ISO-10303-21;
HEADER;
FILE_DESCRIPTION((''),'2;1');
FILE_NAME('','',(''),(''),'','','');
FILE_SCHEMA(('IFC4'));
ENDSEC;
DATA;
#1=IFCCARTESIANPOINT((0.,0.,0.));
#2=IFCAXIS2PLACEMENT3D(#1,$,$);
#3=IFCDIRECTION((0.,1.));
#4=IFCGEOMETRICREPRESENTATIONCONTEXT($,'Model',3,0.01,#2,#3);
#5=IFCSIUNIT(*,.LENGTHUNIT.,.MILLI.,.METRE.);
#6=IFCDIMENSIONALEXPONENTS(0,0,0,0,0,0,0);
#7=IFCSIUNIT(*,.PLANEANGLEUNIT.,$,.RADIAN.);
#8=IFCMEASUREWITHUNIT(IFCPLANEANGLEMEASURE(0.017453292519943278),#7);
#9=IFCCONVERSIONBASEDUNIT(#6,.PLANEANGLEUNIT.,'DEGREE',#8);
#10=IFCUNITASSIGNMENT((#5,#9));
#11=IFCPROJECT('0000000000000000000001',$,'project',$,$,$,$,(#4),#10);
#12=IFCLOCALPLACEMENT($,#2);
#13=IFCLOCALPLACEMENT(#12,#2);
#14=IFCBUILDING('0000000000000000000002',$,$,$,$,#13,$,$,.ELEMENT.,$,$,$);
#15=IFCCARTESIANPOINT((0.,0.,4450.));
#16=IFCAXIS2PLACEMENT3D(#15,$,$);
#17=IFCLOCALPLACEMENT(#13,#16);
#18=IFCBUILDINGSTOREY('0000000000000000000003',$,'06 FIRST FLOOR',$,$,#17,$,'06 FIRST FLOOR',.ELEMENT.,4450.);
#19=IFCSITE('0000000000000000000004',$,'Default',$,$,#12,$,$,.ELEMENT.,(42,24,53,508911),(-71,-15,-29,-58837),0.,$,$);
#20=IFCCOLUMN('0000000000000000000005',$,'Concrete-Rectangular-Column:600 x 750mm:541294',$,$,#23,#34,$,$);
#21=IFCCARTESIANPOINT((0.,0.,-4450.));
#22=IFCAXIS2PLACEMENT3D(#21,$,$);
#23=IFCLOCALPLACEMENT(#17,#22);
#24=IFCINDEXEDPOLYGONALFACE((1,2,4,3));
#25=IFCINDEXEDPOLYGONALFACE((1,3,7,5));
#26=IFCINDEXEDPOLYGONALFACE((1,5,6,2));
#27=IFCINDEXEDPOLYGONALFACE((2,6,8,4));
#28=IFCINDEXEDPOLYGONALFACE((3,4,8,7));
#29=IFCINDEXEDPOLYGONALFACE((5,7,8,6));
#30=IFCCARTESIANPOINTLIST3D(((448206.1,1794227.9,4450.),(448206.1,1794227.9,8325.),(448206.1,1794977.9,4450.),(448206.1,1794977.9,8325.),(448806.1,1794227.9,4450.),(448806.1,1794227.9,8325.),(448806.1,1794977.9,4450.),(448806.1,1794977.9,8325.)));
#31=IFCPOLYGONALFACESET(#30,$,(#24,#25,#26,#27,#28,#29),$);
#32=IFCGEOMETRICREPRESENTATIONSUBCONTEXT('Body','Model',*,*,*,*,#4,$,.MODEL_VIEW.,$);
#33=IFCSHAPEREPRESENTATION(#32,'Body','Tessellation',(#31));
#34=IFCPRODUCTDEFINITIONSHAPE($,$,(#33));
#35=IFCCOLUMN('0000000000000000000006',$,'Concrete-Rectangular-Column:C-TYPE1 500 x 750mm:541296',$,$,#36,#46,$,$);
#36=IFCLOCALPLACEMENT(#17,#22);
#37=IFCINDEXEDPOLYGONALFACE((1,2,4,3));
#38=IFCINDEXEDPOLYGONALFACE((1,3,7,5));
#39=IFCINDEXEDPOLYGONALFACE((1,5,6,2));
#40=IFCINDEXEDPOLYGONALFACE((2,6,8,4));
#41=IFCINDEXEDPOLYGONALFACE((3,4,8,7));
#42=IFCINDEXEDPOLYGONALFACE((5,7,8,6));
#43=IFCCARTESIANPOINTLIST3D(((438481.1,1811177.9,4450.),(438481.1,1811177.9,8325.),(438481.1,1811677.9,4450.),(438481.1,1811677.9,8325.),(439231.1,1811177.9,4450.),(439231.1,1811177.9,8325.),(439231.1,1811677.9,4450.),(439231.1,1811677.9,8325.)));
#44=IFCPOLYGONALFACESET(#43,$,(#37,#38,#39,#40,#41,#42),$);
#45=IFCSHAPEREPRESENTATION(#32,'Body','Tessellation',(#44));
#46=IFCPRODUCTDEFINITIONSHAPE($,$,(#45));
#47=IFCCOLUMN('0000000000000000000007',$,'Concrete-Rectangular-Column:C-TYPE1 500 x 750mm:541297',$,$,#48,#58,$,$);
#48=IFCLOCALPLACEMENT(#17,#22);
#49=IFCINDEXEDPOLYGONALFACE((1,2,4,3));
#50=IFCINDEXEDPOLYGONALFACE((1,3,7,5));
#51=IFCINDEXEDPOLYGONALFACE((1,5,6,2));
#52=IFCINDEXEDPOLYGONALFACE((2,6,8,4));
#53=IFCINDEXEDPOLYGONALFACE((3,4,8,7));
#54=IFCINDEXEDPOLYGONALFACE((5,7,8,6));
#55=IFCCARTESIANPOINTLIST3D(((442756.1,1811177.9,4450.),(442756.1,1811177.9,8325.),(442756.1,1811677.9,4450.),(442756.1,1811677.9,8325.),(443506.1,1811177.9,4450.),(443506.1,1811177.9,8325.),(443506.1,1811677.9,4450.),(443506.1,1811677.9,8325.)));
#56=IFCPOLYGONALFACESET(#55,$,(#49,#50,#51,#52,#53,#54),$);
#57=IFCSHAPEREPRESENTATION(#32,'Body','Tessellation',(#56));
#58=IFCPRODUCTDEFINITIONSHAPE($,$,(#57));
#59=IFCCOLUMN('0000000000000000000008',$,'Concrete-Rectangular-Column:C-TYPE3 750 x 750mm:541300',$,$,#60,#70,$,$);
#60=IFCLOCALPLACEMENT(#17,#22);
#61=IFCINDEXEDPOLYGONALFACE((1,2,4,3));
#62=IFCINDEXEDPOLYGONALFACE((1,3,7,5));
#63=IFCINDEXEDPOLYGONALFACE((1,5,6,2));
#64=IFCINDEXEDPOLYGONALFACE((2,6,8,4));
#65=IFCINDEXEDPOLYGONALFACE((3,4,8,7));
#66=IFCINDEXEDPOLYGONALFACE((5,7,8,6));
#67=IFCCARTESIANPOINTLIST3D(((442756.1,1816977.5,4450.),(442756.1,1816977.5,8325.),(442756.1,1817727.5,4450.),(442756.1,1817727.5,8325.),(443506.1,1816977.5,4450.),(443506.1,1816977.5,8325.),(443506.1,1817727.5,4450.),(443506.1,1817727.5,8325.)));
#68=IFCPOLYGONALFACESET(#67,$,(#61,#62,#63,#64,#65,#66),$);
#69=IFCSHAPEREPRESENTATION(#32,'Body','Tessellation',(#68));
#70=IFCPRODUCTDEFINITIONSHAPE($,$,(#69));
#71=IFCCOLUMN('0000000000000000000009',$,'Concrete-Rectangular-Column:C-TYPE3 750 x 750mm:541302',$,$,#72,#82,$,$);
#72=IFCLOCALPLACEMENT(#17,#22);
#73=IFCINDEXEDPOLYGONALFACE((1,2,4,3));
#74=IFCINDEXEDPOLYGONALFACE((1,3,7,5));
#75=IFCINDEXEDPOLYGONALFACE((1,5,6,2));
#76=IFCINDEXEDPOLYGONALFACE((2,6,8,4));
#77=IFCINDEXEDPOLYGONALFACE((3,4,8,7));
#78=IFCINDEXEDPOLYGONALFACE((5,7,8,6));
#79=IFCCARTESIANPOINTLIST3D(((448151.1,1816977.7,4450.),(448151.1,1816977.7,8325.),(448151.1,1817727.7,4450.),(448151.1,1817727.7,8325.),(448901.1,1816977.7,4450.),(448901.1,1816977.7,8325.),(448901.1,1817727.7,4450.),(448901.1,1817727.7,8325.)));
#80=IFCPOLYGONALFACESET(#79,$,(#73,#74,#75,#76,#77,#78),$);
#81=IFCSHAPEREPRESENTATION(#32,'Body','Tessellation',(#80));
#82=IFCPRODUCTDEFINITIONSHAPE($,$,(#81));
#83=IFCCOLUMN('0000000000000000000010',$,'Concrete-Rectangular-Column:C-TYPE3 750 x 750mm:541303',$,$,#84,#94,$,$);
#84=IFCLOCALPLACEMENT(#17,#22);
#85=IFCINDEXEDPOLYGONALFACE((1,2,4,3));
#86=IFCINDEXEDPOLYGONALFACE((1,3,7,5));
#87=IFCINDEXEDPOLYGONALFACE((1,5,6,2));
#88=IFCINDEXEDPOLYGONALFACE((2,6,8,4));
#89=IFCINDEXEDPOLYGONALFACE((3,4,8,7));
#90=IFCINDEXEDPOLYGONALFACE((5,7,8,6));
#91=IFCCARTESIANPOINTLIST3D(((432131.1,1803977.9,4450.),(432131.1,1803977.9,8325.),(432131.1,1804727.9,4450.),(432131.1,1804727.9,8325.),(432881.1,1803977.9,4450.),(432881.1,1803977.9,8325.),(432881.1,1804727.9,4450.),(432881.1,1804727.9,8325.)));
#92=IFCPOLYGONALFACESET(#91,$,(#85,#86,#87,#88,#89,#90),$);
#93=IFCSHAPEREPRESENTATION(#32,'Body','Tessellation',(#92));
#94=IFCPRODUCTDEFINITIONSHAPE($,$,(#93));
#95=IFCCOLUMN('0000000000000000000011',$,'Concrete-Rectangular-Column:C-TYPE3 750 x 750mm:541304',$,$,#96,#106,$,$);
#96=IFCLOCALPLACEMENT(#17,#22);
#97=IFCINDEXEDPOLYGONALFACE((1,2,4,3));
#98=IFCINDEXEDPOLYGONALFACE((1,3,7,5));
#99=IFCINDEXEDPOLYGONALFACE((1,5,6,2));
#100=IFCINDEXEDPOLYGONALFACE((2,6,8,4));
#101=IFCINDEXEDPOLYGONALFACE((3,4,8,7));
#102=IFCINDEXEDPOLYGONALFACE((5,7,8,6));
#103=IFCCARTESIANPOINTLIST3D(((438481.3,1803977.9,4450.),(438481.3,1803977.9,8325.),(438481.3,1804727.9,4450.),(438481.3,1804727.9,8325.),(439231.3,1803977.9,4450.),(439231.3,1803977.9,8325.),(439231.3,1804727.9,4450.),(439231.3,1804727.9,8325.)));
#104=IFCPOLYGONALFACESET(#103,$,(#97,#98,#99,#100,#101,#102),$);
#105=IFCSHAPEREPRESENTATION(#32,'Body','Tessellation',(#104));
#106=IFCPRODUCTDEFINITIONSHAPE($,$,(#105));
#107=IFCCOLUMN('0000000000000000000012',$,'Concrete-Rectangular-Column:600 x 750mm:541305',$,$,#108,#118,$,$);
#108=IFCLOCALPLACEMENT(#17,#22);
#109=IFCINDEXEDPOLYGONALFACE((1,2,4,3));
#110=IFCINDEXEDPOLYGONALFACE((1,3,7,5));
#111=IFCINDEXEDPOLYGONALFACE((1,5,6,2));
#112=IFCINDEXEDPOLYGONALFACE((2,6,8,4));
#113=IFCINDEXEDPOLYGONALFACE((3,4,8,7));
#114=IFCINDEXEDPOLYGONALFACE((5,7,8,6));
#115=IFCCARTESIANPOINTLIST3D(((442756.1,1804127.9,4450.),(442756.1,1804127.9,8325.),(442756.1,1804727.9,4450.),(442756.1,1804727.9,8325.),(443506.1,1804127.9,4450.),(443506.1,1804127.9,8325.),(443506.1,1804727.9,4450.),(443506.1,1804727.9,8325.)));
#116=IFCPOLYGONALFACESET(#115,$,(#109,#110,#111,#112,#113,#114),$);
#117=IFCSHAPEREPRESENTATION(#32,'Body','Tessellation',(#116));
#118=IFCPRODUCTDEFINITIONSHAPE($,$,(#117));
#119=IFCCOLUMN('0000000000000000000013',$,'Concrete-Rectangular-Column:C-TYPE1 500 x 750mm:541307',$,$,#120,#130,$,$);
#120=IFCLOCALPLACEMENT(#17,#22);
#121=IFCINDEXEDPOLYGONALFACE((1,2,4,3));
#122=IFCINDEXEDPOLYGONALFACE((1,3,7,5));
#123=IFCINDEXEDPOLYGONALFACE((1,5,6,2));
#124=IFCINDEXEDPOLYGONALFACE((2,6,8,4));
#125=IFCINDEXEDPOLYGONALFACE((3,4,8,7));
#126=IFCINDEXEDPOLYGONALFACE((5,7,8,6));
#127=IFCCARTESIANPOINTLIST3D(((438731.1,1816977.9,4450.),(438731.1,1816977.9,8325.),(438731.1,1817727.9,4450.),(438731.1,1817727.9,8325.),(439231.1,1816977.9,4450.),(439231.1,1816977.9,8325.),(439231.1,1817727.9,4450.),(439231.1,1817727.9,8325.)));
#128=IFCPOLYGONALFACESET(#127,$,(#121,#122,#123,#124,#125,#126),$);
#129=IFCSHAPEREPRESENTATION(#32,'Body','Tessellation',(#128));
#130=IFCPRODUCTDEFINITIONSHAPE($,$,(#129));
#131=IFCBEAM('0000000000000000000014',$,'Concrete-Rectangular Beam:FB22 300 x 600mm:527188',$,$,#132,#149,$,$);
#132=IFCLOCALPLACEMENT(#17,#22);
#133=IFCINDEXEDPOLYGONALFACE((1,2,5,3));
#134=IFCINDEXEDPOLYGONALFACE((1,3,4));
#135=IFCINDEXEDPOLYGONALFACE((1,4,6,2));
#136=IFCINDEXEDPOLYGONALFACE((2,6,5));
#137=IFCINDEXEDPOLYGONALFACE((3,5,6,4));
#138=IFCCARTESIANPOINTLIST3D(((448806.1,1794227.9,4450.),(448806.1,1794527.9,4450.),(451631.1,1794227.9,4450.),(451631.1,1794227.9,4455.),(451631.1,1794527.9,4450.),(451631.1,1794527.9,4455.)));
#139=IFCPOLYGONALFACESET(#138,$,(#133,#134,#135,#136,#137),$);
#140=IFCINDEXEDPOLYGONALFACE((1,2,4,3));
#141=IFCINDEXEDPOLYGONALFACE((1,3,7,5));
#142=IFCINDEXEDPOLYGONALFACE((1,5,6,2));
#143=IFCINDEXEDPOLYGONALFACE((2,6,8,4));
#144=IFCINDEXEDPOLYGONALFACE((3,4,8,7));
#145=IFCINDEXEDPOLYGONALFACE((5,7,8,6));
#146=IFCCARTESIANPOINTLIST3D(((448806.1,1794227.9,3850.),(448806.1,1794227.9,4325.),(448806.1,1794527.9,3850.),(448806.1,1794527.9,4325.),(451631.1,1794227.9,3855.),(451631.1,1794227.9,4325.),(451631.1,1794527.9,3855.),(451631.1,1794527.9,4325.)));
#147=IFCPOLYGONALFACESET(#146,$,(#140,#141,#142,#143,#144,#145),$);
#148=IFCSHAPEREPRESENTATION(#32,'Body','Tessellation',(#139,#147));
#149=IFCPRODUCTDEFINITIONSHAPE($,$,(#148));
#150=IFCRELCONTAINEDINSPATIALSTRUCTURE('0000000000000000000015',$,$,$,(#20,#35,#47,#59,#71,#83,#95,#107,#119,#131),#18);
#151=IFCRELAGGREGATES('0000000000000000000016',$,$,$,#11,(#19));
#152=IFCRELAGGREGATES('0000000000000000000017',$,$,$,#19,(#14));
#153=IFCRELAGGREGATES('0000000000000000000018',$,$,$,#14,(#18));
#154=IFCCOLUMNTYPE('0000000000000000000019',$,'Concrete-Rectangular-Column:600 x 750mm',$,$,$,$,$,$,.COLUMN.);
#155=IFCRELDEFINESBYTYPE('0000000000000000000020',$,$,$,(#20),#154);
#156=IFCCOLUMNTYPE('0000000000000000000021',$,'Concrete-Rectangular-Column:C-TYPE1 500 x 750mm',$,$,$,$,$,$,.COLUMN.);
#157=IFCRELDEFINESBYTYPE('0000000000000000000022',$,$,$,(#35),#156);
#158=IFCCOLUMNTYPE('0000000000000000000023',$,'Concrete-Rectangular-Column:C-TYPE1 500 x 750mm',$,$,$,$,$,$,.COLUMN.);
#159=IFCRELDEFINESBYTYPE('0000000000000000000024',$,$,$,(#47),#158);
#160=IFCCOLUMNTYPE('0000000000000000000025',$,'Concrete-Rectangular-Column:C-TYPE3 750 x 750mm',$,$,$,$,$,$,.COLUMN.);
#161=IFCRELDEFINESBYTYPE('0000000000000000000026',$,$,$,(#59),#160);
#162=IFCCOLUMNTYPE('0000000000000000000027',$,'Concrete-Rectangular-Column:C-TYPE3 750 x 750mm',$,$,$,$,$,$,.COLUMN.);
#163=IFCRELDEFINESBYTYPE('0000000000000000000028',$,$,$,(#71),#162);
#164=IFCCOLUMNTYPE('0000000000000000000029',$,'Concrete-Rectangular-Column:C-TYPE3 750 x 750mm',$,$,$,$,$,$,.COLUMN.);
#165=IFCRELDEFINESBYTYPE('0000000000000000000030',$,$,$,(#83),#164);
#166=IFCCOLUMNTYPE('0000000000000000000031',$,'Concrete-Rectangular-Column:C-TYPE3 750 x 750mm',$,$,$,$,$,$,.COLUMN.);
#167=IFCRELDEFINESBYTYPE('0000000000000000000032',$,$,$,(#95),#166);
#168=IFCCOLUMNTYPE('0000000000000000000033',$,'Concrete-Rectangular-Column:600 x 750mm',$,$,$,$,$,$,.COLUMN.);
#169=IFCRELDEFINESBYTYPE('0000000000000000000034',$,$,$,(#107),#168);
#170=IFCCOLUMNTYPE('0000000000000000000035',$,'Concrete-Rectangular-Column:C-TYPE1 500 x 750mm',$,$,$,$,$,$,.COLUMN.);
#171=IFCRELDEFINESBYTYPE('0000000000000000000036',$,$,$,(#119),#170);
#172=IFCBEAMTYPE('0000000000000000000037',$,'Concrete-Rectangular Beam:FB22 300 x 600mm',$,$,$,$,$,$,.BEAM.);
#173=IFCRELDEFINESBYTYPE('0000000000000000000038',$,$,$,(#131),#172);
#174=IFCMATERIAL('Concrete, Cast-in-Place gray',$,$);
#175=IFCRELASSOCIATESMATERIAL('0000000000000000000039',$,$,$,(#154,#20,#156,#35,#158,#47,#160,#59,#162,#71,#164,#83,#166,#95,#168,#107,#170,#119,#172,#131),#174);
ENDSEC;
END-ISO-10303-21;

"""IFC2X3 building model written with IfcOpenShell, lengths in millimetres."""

from ifc_helpers import new_model, entity, si_unit, converted_unit, direction, frame, frame_2d, origin, place, context, subcontext, project, spatial, polyline, rectangle, extrude, clip, halfspace, bounded_halfspace, source, transform, mapped, material, type_object, type_shapes, element, save


model = new_model("IFC2X3")

# Units and contexts
model_context = context("Model", 3, precision=0.01, world=origin(), true_north=direction((0.0, 1.0)))
body_context = subcontext(model_context, "Body", "Model", "MODEL_VIEW")
ifc_project = project(units=[si_unit("LENGTHUNIT", "METRE", prefix="MILLI"), converted_unit("PLANEANGLEUNIT", "DEGREE", entity("IfcPlaneAngleMeasure", 0.017453292519943278), si_unit("PLANEANGLEUNIT", "RADIAN"), dimensions=[0, 0, 0, 0, 0, 0, 0])], contexts=[model_context])

# Site, building, storey
site_placement = place(None, origin())
site = spatial("IfcSite", under=ifc_project, at=site_placement, Name="Default", CompositionType="ELEMENT", RefLatitude=(42, 24, 53, 508911), RefLongitude=(-71, -15, -29, -58837), RefElevation=0.0)
building_placement = place(site_placement, origin())
building = spatial("IfcBuilding", under=site, at=building_placement, CompositionType="ELEMENT")
storey_placement = place(building_placement, frame((0.0, 0.0, 4450.0)))
storey = spatial("IfcBuildingStorey", under=building, at=storey_placement, Name="06 FIRST FLOOR", LongName="06 FIRST FLOOR", CompositionType="ELEMENT", Elevation=4450.0)

# Columns
ifc_material_1 = material(Name="Concrete, Cast-in-Place gray")
column_type_1 = type_object("IfcColumnType", Name="Concrete-Rectangular-Column:600 x 750mm", PredefinedType="COLUMN", material=ifc_material_1)
shared_shape_1 = source(origin(), body_context, "Body", "SweptSolid", [
    extrude(rectangle(XDim=3875.0, YDim=750.0, at=frame_2d((0.0, 0.0), x_axis=(1.0, 0.0))), frame((448206.1, 1794602.9, 6387.5), z_axis=(1.0, 0.0, 0.0), x_axis=(0.0, 0.0, 1.0)), (0.0, 0.0, 1.0), 600.0),
])
type_shapes(column_type_1, [shared_shape_1])
column_1_placement = place(storey_placement, frame((0.0, 0.0, -4450.0)))
element("IfcColumn", 1, at=column_1_placement, inside=storey, type_object=column_type_1, material=ifc_material_1, Name="Concrete-Rectangular-Column:600 x 750mm:541294", context=body_context, shape_type="MappedRepresentation", body=[
    mapped(shared_shape_1, transform((0.0, 0.0, 0.0), scale=1.0)),
])
column_type_2 = type_object("IfcColumnType", Name="Concrete-Rectangular-Column:C-TYPE1 500 x 750mm", PredefinedType="COLUMN", material=ifc_material_1)
shared_shape_2 = source(origin(), body_context, "Body", "SweptSolid", [
    extrude(rectangle(XDim=500.0, YDim=750.0, at=frame_2d((0.0, 0.0), x_axis=(1.0, 0.0))), frame((438856.1, 1811427.9, 4450.0), z_axis=(0.0, 0.0, 1.0), x_axis=(0.0, -1.0, 0.0)), (0.0, 0.0, 1.0), 3875.0),
])
type_shapes(column_type_2, [shared_shape_2])
column_2_placement = place(storey_placement, frame((0.0, 0.0, -4450.0)))
element("IfcColumn", 2, at=column_2_placement, inside=storey, type_object=column_type_2, material=ifc_material_1, Name="Concrete-Rectangular-Column:C-TYPE1 500 x 750mm:541296", context=body_context, shape_type="MappedRepresentation", body=[
    mapped(shared_shape_2, transform((0.0, 0.0, 0.0), scale=1.0)),
])
column_type_3 = type_object("IfcColumnType", Name="Concrete-Rectangular-Column:C-TYPE1 500 x 750mm", PredefinedType="COLUMN", material=ifc_material_1)
shared_shape_3 = source(origin(), body_context, "Body", "SweptSolid", [
    extrude(rectangle(XDim=500.0, YDim=750.0, at=frame_2d((0.0, 0.0), x_axis=(1.0, 0.0))), frame((443131.1, 1811427.9, 4450.0), z_axis=(0.0, 0.0, 1.0), x_axis=(0.0, -1.0, 0.0)), (0.0, 0.0, 1.0), 3875.0),
])
type_shapes(column_type_3, [shared_shape_3])
column_3_placement = place(storey_placement, frame((0.0, 0.0, -4450.0)))
element("IfcColumn", 3, at=column_3_placement, inside=storey, type_object=column_type_3, material=ifc_material_1, Name="Concrete-Rectangular-Column:C-TYPE1 500 x 750mm:541297", context=body_context, shape_type="MappedRepresentation", body=[
    mapped(shared_shape_3, transform((0.0, 0.0, 0.0), scale=1.0)),
])
column_type_4 = type_object("IfcColumnType", Name="Concrete-Rectangular-Column:C-TYPE3 750 x 750mm", PredefinedType="COLUMN", material=ifc_material_1)
shared_shape_4 = source(origin(), body_context, "Body", "SweptSolid", [
    extrude(rectangle(XDim=750.0, YDim=750.0, at=frame_2d((0.0, 0.0), x_axis=(1.0, 0.0))), frame((443131.1, 1817352.5, 4450.0), z_axis=(0.0, 0.0, 1.0), x_axis=(0.0, -1.0, 0.0)), (0.0, 0.0, 1.0), 3875.0),
])
type_shapes(column_type_4, [shared_shape_4])
column_4_placement = place(storey_placement, frame((0.0, 0.0, -4450.0)))
element("IfcColumn", 4, at=column_4_placement, inside=storey, type_object=column_type_4, material=ifc_material_1, Name="Concrete-Rectangular-Column:C-TYPE3 750 x 750mm:541300", context=body_context, shape_type="MappedRepresentation", body=[
    mapped(shared_shape_4, transform((0.0, 0.0, 0.0), scale=1.0)),
])
column_type_5 = type_object("IfcColumnType", Name="Concrete-Rectangular-Column:C-TYPE3 750 x 750mm", PredefinedType="COLUMN", material=ifc_material_1)
shared_shape_5 = source(origin(), body_context, "Body", "SweptSolid", [
    extrude(rectangle(XDim=750.0, YDim=750.0, at=frame_2d((0.0, 0.0), x_axis=(1.0, 0.0))), frame((448526.1, 1817352.7, 4450.0), z_axis=(0.0, 0.0, 1.0), x_axis=(0.0, -1.0, 0.0)), (0.0, 0.0, 1.0), 3875.0),
])
type_shapes(column_type_5, [shared_shape_5])
column_5_placement = place(storey_placement, frame((0.0, 0.0, -4450.0)))
element("IfcColumn", 5, at=column_5_placement, inside=storey, type_object=column_type_5, material=ifc_material_1, Name="Concrete-Rectangular-Column:C-TYPE3 750 x 750mm:541302", context=body_context, shape_type="MappedRepresentation", body=[
    mapped(shared_shape_5, transform((0.0, 0.0, 0.0), scale=1.0)),
])
column_type_6 = type_object("IfcColumnType", Name="Concrete-Rectangular-Column:C-TYPE3 750 x 750mm", PredefinedType="COLUMN", material=ifc_material_1)
shared_shape_6 = source(origin(), body_context, "Body", "SweptSolid", [
    extrude(rectangle(XDim=750.0, YDim=750.0, at=frame_2d((0.0, 0.0), x_axis=(1.0, 0.0))), frame((432506.1, 1804352.9, 4450.0), z_axis=(0.0, 0.0, 1.0), x_axis=(0.0, -1.0, 0.0)), (0.0, 0.0, 1.0), 3875.0),
])
type_shapes(column_type_6, [shared_shape_6])
column_6_placement = place(storey_placement, frame((0.0, 0.0, -4450.0)))
element("IfcColumn", 6, at=column_6_placement, inside=storey, type_object=column_type_6, material=ifc_material_1, Name="Concrete-Rectangular-Column:C-TYPE3 750 x 750mm:541303", context=body_context, shape_type="MappedRepresentation", body=[
    mapped(shared_shape_6, transform((0.0, 0.0, 0.0), scale=1.0)),
])
column_type_7 = type_object("IfcColumnType", Name="Concrete-Rectangular-Column:C-TYPE3 750 x 750mm", PredefinedType="COLUMN", material=ifc_material_1)
shared_shape_7 = source(origin(), body_context, "Body", "SweptSolid", [
    extrude(rectangle(XDim=750.0, YDim=750.0, at=frame_2d((0.0, 0.0), x_axis=(1.0, 0.0))), frame((438856.3, 1804352.9, 4450.0), z_axis=(0.0, 0.0, 1.0), x_axis=(0.0, -1.0, 0.0)), (0.0, 0.0, 1.0), 3875.0),
])
type_shapes(column_type_7, [shared_shape_7])
column_7_placement = place(storey_placement, frame((0.0, 0.0, -4450.0)))
element("IfcColumn", 7, at=column_7_placement, inside=storey, type_object=column_type_7, material=ifc_material_1, Name="Concrete-Rectangular-Column:C-TYPE3 750 x 750mm:541304", context=body_context, shape_type="MappedRepresentation", body=[
    mapped(shared_shape_7, transform((0.0, 0.0, 0.0), scale=1.0)),
])
column_type_8 = type_object("IfcColumnType", Name="Concrete-Rectangular-Column:600 x 750mm", PredefinedType="COLUMN", material=ifc_material_1)
shared_shape_8 = source(origin(), body_context, "Body", "SweptSolid", [
    extrude(rectangle(XDim=600.0, YDim=750.0, at=frame_2d((0.0, 0.0), x_axis=(1.0, 0.0))), frame((443131.1, 1804427.9, 4450.0), z_axis=(0.0, 0.0, 1.0), x_axis=(0.0, -1.0, 0.0)), (0.0, 0.0, 1.0), 3875.0),
])
type_shapes(column_type_8, [shared_shape_8])
column_8_placement = place(storey_placement, frame((0.0, 0.0, -4450.0)))
element("IfcColumn", 8, at=column_8_placement, inside=storey, type_object=column_type_8, material=ifc_material_1, Name="Concrete-Rectangular-Column:600 x 750mm:541305", context=body_context, shape_type="MappedRepresentation", body=[
    mapped(shared_shape_8, transform((0.0, 0.0, 0.0), scale=1.0)),
])
column_type_9 = type_object("IfcColumnType", Name="Concrete-Rectangular-Column:C-TYPE1 500 x 750mm", PredefinedType="COLUMN", material=ifc_material_1)
shared_shape_9 = source(origin(), body_context, "Body", "SweptSolid", [
    extrude(rectangle(XDim=3875.0, YDim=750.0, at=frame_2d((0.0, 0.0), x_axis=(1.0, 0.0))), frame((438731.1, 1817352.9, 6387.5), z_axis=(1.0, 0.0, 0.0), x_axis=(0.0, 0.0, 1.0)), (0.0, 0.0, 1.0), 500.0),
])
type_shapes(column_type_9, [shared_shape_9])
column_9_placement = place(storey_placement, frame((0.0, 0.0, -4450.0)))
element("IfcColumn", 9, at=column_9_placement, inside=storey, type_object=column_type_9, material=ifc_material_1, Name="Concrete-Rectangular-Column:C-TYPE1 500 x 750mm:541307", context=body_context, shape_type="MappedRepresentation", body=[
    mapped(shared_shape_9, transform((0.0, 0.0, 0.0), scale=1.0)),
])

# Beam
beam_type_1 = type_object("IfcBeamType", Name="Concrete-Rectangular Beam:FB22 300 x 600mm", PredefinedType="BEAM", material=ifc_material_1)
shared_shape_10 = source(origin(), body_context, "Body", "Clipping", [
    clip(clip(extrude(rectangle(XDim=5.0, YDim=300.0, at=frame_2d((0.0, 0.0), x_axis=(0.0, 1.0))), frame((448806.1, 1794377.9, 4447.5), z_axis=(0.999998, 0.0, 0.00177), x_axis=(0.0, -1.0, 0.0)), (0.0, 0.0, 1.0), 2825.0), halfspace(frame((443506.1, 1824227.9, 4450.0), z_axis=(0.0, 0.0, -1.0), x_axis=(0.0, 1.0, 0.0)), False)), halfspace(frame((451631.1, 1794527.9, 4455.0), z_axis=(1.0, 0.0, 0.0), x_axis=(0.0, 1.0, 0.0)), False)),
    clip(clip(clip(extrude(rectangle(XDim=475.0, YDim=300.0, at=frame_2d((0.0, 0.0), x_axis=(0.0, 1.0))), frame((448805.7, 1794377.9, 4087.5), z_axis=(0.999998, 0.0, 0.00177), x_axis=(0.0, -1.0, 0.0)), (0.0, 0.0, 1.0), 2825.8), halfspace(frame((448806.1, 1794527.9, 4450.0), z_axis=(-1.0, 0.0, 0.0), x_axis=(0.0, -1.0, 0.0)), False)), bounded_halfspace(frame((451631.1, 1794527.9, 4455.0), z_axis=(1.0, 0.0, 0.0), x_axis=(0.0, 1.0, 0.0)), False, frame((448805.7, 1794377.9, 4087.5), z_axis=(0.999998, 0.0, 0.00177), x_axis=(0.0, -1.0, 0.0)), polyline([(150.0, 237.5), (-150.0, 237.5), (-150.0, -232.5), (150.0, -232.5), (150.0, 237.5)]))), bounded_halfspace(frame((443506.1, 1824227.9, 4325.0), z_axis=(0.0, 0.0, 1.0), x_axis=(0.0, -1.0, 0.0)), False, frame((448805.7, 1794377.9, 4087.5), z_axis=(0.999998, 0.0, 0.00177), x_axis=(0.0, -1.0, 0.0)), polyline([(150.0, -237.5), (150.0, -232.5), (-150.0, -232.5), (-150.0, -237.5), (150.0, -237.5)]))),
])
type_shapes(beam_type_1, [shared_shape_10])
beam_1_placement = place(storey_placement, frame((0.0, 0.0, -4450.0)))
element("IfcBeam", 10, at=beam_1_placement, inside=storey, type_object=beam_type_1, material=ifc_material_1, Name="Concrete-Rectangular Beam:FB22 300 x 600mm:527188", context=body_context, shape_type="MappedRepresentation", body=[
    mapped(shared_shape_10, transform((0.0, 0.0, 0.0), scale=1.0)),
])

save(model, "model.ifc")
